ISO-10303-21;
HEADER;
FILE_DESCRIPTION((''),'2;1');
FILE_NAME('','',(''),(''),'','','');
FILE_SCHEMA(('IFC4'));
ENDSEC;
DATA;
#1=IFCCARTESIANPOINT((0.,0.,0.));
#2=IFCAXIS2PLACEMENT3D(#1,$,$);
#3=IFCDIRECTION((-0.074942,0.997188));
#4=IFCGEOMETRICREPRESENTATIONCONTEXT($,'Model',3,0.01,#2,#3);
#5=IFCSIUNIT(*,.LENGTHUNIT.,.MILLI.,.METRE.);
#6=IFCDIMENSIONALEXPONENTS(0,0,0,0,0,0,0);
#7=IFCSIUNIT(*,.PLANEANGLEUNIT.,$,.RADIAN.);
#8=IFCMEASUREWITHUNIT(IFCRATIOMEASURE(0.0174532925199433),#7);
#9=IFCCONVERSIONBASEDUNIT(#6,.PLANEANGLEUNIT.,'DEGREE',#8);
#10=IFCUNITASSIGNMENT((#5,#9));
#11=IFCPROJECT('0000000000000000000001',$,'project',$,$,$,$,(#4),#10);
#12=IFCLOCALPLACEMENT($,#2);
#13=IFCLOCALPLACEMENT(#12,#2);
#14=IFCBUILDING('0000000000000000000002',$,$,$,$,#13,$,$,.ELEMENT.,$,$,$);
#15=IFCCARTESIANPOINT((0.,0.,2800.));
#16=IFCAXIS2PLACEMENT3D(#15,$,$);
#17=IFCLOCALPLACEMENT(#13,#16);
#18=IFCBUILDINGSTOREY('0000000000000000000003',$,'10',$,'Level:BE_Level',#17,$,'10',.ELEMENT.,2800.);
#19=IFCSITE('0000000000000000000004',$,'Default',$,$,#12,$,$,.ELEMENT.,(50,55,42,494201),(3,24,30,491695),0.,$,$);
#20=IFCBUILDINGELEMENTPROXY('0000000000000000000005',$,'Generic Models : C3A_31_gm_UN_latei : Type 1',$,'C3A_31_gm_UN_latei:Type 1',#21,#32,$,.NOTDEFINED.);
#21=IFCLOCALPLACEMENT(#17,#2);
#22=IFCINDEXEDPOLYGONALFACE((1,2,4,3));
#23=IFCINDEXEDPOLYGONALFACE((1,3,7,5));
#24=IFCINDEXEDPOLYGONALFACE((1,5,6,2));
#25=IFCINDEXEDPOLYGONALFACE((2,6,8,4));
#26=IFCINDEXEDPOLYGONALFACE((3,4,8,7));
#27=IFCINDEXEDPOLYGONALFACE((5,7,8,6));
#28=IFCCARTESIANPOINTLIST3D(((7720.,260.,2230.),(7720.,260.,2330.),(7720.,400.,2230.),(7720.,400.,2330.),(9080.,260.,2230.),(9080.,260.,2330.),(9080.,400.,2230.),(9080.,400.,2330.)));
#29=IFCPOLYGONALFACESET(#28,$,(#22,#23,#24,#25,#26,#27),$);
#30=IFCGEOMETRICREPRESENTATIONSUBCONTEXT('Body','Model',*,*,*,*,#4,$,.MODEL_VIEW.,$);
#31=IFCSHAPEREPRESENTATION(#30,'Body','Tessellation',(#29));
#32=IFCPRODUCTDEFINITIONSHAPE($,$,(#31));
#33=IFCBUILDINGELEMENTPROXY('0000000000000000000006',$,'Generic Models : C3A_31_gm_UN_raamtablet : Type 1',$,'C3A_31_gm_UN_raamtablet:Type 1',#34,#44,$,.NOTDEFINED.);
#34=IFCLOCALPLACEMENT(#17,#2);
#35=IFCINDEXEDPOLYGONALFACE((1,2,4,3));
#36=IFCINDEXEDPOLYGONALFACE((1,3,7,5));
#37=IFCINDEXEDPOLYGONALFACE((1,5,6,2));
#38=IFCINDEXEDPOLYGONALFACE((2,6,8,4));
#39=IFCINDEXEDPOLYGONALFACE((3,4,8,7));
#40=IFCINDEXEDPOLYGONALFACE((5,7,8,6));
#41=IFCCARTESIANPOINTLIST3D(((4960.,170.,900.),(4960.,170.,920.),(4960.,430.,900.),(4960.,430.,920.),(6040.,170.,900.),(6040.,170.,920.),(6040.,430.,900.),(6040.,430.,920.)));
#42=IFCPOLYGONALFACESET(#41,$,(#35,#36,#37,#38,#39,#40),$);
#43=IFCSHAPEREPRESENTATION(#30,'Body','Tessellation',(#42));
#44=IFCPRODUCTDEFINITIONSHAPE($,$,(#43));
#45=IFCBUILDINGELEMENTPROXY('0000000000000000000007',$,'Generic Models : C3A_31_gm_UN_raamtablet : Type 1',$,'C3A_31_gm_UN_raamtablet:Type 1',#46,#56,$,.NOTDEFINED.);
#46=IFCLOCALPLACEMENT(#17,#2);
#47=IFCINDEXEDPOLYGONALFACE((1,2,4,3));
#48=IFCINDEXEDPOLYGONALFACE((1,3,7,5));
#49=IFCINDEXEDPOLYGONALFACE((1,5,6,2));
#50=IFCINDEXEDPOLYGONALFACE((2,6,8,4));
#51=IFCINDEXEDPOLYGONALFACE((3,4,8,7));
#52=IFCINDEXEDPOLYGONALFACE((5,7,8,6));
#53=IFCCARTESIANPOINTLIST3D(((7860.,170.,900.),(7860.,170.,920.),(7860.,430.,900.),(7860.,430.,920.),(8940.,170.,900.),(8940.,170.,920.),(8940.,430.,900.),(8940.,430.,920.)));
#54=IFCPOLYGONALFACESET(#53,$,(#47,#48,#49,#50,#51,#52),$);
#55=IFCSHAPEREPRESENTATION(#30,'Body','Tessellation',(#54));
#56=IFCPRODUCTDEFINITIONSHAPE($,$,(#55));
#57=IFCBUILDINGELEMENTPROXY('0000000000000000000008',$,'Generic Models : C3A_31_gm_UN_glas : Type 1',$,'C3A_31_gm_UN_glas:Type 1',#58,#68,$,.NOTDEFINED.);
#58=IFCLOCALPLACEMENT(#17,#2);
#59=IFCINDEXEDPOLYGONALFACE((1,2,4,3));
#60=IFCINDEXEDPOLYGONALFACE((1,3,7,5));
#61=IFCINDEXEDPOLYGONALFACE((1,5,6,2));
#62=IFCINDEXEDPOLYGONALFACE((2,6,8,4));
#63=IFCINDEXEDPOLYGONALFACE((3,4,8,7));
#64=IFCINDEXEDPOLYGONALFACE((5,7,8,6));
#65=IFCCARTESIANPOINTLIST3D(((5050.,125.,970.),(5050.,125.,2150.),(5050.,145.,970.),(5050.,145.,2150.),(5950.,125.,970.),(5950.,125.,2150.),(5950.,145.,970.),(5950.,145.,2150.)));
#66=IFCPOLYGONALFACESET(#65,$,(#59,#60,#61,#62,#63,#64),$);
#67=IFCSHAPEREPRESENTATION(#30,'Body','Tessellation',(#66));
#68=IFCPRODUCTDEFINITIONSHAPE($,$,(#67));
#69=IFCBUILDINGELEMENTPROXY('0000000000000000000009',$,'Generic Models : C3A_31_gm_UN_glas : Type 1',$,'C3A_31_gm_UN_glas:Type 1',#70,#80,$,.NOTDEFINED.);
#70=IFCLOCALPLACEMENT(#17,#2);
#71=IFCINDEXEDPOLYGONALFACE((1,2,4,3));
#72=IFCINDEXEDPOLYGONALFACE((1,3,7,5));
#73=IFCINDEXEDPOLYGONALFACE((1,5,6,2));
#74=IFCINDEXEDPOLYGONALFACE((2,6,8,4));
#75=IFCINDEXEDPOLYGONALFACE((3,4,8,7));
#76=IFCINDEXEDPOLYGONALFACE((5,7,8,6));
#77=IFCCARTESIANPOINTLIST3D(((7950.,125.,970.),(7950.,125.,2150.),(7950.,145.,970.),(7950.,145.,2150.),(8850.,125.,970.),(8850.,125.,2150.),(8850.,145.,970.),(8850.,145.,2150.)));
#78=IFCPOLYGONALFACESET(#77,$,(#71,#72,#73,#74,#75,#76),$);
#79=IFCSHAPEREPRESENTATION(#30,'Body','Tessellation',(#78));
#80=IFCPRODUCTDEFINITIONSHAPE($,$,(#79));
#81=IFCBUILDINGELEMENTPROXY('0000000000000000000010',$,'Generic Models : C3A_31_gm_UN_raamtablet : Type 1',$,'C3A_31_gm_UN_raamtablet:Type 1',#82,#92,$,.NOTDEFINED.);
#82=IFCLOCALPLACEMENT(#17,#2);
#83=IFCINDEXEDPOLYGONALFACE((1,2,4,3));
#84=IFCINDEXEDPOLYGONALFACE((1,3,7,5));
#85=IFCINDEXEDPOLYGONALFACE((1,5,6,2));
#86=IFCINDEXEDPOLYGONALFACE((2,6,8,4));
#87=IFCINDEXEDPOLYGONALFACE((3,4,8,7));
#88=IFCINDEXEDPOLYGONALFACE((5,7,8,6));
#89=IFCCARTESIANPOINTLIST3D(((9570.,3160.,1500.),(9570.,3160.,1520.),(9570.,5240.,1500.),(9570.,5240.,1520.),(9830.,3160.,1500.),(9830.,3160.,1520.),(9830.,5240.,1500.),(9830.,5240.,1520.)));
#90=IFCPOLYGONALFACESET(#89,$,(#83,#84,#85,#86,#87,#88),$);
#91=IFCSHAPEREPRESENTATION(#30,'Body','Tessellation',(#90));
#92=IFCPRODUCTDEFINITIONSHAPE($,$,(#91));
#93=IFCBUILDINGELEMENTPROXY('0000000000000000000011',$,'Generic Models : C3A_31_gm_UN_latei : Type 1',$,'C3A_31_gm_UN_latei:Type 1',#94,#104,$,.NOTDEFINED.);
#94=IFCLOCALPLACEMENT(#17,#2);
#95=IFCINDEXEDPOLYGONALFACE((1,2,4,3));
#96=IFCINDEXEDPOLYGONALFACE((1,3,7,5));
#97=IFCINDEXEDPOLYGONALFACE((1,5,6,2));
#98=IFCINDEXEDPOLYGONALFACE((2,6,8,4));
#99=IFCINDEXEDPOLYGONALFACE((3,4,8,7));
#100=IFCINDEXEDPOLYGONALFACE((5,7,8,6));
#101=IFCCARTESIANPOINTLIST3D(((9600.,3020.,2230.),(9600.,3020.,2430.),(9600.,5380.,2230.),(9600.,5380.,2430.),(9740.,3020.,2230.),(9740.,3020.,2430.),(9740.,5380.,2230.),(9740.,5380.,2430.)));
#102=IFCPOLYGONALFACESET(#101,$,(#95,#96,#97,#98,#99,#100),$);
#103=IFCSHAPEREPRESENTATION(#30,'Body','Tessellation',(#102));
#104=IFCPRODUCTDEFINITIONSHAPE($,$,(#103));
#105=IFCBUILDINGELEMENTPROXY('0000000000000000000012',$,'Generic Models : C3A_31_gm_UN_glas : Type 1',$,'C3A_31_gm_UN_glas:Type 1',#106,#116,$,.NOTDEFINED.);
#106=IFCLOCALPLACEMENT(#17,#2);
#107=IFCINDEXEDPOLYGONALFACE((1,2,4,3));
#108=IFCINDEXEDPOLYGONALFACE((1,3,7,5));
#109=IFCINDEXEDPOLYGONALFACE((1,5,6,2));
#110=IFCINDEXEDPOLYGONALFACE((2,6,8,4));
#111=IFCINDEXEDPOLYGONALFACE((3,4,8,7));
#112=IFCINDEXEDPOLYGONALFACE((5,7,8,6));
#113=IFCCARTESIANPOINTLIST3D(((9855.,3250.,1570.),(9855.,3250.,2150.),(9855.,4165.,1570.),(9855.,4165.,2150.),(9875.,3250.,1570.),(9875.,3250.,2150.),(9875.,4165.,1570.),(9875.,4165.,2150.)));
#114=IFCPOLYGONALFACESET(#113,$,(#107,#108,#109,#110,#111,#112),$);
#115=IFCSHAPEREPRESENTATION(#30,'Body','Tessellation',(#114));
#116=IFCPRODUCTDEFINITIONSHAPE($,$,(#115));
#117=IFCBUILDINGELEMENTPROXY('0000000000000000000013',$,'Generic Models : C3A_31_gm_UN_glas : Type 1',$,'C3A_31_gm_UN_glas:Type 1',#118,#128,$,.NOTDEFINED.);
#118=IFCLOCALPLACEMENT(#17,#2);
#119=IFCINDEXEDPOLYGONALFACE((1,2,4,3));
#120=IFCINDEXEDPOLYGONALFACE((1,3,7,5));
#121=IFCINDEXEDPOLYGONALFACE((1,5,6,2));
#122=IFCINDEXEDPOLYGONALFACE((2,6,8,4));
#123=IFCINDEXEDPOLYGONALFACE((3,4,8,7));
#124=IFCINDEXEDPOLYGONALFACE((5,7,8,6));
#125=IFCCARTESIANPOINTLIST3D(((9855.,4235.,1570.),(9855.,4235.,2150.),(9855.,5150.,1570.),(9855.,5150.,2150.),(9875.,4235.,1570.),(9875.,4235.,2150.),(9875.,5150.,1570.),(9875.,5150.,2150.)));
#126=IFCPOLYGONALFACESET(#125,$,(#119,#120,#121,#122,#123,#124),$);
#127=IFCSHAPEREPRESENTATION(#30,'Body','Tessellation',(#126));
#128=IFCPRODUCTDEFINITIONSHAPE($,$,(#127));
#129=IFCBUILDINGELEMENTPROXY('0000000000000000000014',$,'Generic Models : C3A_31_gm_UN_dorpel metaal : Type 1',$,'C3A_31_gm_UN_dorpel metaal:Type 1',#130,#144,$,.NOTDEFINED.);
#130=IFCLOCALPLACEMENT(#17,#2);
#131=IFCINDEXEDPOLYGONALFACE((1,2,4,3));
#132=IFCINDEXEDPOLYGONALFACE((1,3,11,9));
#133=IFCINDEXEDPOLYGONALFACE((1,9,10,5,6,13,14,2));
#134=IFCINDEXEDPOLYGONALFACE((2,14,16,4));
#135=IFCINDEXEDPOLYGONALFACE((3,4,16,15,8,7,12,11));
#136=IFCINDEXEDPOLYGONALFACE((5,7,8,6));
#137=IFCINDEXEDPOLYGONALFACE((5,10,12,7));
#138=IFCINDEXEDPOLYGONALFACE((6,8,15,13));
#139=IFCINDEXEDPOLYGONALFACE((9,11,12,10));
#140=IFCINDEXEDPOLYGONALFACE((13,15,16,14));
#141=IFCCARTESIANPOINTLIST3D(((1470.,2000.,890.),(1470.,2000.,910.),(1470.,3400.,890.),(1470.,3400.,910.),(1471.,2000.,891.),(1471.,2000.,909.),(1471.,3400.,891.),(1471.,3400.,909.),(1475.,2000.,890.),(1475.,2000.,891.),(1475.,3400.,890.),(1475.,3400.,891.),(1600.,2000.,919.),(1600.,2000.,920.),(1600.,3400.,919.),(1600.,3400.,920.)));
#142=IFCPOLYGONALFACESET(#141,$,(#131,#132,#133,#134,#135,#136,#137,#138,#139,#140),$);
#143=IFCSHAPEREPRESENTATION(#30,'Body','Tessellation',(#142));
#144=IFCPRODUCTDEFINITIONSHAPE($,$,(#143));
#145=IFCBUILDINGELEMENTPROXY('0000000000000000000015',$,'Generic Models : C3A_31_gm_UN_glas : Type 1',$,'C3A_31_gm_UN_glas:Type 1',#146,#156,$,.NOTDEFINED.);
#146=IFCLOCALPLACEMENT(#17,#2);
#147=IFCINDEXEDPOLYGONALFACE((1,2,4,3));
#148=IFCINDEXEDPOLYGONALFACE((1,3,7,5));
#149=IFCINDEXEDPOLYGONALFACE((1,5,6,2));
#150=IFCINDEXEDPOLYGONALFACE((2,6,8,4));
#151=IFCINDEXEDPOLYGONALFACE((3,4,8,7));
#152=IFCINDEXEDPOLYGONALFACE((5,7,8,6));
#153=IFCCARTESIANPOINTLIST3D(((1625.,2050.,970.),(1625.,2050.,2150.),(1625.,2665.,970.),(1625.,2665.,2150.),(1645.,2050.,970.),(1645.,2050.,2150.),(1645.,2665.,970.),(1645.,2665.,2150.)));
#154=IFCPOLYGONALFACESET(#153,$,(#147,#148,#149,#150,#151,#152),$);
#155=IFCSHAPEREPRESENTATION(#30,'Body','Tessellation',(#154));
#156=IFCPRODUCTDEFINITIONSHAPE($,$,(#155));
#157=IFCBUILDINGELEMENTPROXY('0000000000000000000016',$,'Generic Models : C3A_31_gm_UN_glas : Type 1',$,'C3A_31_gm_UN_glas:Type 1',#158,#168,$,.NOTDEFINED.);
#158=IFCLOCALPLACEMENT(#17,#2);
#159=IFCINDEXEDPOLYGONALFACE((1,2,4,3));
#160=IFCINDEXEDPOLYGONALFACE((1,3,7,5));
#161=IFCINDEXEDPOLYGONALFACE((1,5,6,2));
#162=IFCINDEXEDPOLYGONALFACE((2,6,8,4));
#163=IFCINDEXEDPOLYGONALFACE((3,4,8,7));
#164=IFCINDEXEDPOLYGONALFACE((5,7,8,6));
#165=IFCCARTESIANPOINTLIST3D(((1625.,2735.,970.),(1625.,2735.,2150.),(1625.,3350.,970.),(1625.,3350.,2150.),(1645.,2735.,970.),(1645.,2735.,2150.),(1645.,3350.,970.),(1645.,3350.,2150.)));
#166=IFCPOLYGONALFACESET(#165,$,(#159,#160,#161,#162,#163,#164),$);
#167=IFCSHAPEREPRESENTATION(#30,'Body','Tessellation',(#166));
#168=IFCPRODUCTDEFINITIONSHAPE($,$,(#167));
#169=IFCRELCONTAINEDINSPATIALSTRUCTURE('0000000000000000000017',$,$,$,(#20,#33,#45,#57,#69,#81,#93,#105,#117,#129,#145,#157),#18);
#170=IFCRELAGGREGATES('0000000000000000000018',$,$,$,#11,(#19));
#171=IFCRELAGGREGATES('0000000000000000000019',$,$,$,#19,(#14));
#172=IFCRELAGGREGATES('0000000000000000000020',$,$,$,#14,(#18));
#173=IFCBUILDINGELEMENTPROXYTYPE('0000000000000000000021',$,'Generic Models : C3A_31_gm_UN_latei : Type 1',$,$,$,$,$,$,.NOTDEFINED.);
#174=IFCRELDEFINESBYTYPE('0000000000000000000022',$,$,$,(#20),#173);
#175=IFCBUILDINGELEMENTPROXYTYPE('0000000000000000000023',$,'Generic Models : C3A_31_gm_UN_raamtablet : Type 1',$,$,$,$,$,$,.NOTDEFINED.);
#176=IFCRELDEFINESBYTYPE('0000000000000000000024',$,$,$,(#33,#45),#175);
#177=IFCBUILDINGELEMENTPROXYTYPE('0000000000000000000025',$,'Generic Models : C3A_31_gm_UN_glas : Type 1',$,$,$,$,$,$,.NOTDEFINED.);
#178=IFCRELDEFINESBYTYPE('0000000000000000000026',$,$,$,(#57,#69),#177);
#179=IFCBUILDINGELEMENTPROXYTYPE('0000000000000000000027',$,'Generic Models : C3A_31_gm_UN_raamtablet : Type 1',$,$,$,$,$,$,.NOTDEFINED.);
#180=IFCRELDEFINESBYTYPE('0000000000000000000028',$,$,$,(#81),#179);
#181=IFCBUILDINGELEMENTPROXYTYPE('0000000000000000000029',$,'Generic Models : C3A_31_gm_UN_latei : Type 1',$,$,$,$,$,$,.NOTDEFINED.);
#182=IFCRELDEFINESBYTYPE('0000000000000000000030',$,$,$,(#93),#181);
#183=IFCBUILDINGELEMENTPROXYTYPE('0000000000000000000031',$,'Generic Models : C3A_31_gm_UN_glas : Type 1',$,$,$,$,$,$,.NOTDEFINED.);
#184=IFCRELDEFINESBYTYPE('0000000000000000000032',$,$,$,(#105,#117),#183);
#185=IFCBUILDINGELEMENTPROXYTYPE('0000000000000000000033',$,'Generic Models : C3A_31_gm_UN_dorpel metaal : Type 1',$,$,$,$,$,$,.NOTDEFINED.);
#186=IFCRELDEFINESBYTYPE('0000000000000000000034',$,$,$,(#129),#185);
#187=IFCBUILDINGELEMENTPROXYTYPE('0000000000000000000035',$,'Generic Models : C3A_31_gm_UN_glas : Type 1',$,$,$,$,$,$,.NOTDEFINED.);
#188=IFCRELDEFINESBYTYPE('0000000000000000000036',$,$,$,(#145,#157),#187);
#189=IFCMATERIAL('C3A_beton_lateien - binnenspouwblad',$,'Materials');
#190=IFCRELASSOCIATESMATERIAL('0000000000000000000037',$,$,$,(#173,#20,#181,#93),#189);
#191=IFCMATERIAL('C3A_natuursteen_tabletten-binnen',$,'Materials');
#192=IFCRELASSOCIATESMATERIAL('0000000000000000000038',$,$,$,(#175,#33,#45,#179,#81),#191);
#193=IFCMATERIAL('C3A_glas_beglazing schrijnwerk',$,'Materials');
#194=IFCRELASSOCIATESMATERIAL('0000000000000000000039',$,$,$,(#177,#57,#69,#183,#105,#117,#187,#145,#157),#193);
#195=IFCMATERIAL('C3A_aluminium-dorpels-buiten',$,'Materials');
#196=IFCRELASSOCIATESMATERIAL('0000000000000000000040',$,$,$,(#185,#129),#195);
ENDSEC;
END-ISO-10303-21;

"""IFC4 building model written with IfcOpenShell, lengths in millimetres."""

from ifc_helpers import new_model, entity, si_unit, converted_unit, direction, frame, frame_2d, origin, origin_2d_with_axis, place, context, subcontext, project, spatial, polyline, rectangle, outline, extrude, source, transform, mapped, material, type_object, type_shapes, element, save


model = new_model("IFC4")

# Units and contexts
model_context = context("Model", 3, precision=0.01, world=origin(), true_north=direction((-0.074942, 0.997188)))
body_context = subcontext(model_context, "Body", "Model", "MODEL_VIEW")
ifc_project = project(units=[si_unit("LENGTHUNIT", "METRE", prefix="MILLI"), converted_unit("PLANEANGLEUNIT", "DEGREE", entity("IfcRatioMeasure", 0.0174532925199433), si_unit("PLANEANGLEUNIT", "RADIAN"), dimensions=[0, 0, 0, 0, 0, 0, 0])], contexts=[model_context])

# Site, building, storey
site_placement = place(None, origin())
site = spatial("IfcSite", under=ifc_project, at=site_placement, Name="Default", CompositionType="ELEMENT", RefLatitude=(50, 55, 42, 494201), RefLongitude=(3, 24, 30, 491695), RefElevation=0.0)
building_placement = place(site_placement, origin())
building = spatial("IfcBuilding", under=site, at=building_placement, CompositionType="ELEMENT")
storey_placement = place(building_placement, frame((0.0, 0.0, 2800.0)))
storey = spatial("IfcBuildingStorey", under=building, at=storey_placement, Name="10", ObjectType="Level:BE_Level", LongName="10", CompositionType="ELEMENT", Elevation=2800.0)

# Building element proxies
ifc_material_1 = material(Name="C3A_natuursteen_tabletten-binnen", Category="Materials")
ifc_material_2 = material(Name="C3A_beton_lateien - binnenspouwblad", Category="Materials")
building_element_proxy_type_1 = type_object("IfcBuildingElementProxyType", Name="Generic Models : C3A_31_gm_UN_latei : Type 1", PredefinedType="NOTDEFINED", material=ifc_material_2)
shared_shape_1 = source(origin(), body_context, "Body", "SweptSolid", [
    extrude(rectangle(XDim=1360.0, YDim=140.0, at=origin_2d_with_axis()), frame((0.0, 70.0, 0.0), z_axis=(0.0, 0.0, 1.0), x_axis=(-1.0, 0.0, 0.0)), (0.0, 0.0, 1.0), 100.0),
])
type_shapes(building_element_proxy_type_1, [shared_shape_1])
for number, where, z_axis, x_axis, name in (
    (1, (8400.0, 400.0, 2230.0), (0.0, 0.0, 1.0), (-1.0, 0.0, 0.0), "Generic Models : C3A_31_gm_UN_latei : Type 1"),
):
    element("IfcBuildingElementProxy", number, at=place(storey_placement, frame(where, z_axis=z_axis, x_axis=x_axis)), inside=storey, type_object=building_element_proxy_type_1, material=ifc_material_2, Name=name, ObjectType="C3A_31_gm_UN_latei:Type 1", PredefinedType="NOTDEFINED", context=body_context, shape_type="MappedRepresentation", body=[
        mapped(shared_shape_1, transform((0.0, 0.0, 0.0), scale=1.0)),
    ])
building_element_proxy_type_2 = type_object("IfcBuildingElementProxyType", Name="Generic Models : C3A_31_gm_UN_raamtablet : Type 1", PredefinedType="NOTDEFINED", material=ifc_material_1)
shared_shape_2 = source(origin(), body_context, "Body", "SweptSolid", [
    extrude(rectangle(XDim=1080.0, YDim=260.0, at=origin_2d_with_axis()), frame((0.0, 130.0, 0.0), z_axis=(0.0, 0.0, 1.0), x_axis=(-1.0, 0.0, 0.0)), (0.0, 0.0, 1.0), 20.0),
])
type_shapes(building_element_proxy_type_2, [shared_shape_2])
for number, where, z_axis, x_axis, name in (
    (2, (5500.0, 430.0, 900.0), (0.0, 0.0, 1.0), (-1.0, 0.0, 0.0), "Generic Models : C3A_31_gm_UN_raamtablet : Type 1"),
    (3, (8400.0, 430.0, 900.0), (0.0, 0.0, 1.0), (-1.0, 0.0, 0.0), "Generic Models : C3A_31_gm_UN_raamtablet : Type 1"),
):
    element("IfcBuildingElementProxy", number, at=place(storey_placement, frame(where, z_axis=z_axis, x_axis=x_axis)), inside=storey, type_object=building_element_proxy_type_2, material=ifc_material_1, Name=name, ObjectType="C3A_31_gm_UN_raamtablet:Type 1", PredefinedType="NOTDEFINED", context=body_context, shape_type="MappedRepresentation", body=[
        mapped(shared_shape_2, transform((0.0, 0.0, 0.0), scale=1.0)),
    ])
ifc_material_3 = material(Name="C3A_glas_beglazing schrijnwerk", Category="Materials")
building_element_proxy_type_3 = type_object("IfcBuildingElementProxyType", Name="Generic Models : C3A_31_gm_UN_glas : Type 1", PredefinedType="NOTDEFINED", material=ifc_material_3)
shared_shape_3 = source(origin(), body_context, "Body", "SweptSolid", [
    extrude(rectangle(XDim=900.0, YDim=20.0, at=origin_2d_with_axis()), frame((450.0, 10.0, 0.0), z_axis=(0.0, 0.0, 1.0), x_axis=(-1.0, 0.0, 0.0)), (0.0, 0.0, 1.0), 1180.0),
])
type_shapes(building_element_proxy_type_3, [shared_shape_3])
for number, where, z_axis, x_axis, name in (
    (4, (5950.0, 145.0, 970.0), (0.0, 0.0, 1.0), (-1.0, 0.0, 0.0), "Generic Models : C3A_31_gm_UN_glas : Type 1"),
    (5, (8850.0, 145.0, 970.0), (0.0, 0.0, 1.0), (-1.0, 0.0, 0.0), "Generic Models : C3A_31_gm_UN_glas : Type 1"),
):
    element("IfcBuildingElementProxy", number, at=place(storey_placement, frame(where, z_axis=z_axis, x_axis=x_axis)), inside=storey, type_object=building_element_proxy_type_3, material=ifc_material_3, Name=name, ObjectType="C3A_31_gm_UN_glas:Type 1", PredefinedType="NOTDEFINED", context=body_context, shape_type="MappedRepresentation", body=[
        mapped(shared_shape_3, transform((0.0, 0.0, 0.0), scale=1.0)),
    ])
ifc_material_4 = material(Name="C3A_aluminium-dorpels-buiten", Category="Materials")
building_element_proxy_type_4 = type_object("IfcBuildingElementProxyType", Name="Generic Models : C3A_31_gm_UN_raamtablet : Type 1", PredefinedType="NOTDEFINED", material=ifc_material_1)
shared_shape_4 = source(origin(), body_context, "Body", "SweptSolid", [
    extrude(rectangle(XDim=260.0, YDim=2080.0, at=origin_2d_with_axis()), frame((0.0, -130.0, 0.0), z_axis=(0.0, 0.0, 1.0), x_axis=(0.0, 1.0, 0.0)), (0.0, 0.0, 1.0), 20.0),
])
type_shapes(building_element_proxy_type_4, [shared_shape_4])
proxy_1_placement = place(storey_placement, frame((9570.0, 4200.0, 1500.0), z_axis=(0.0, 0.0, 1.0), x_axis=(0.0, 1.0, 0.0)))
element("IfcBuildingElementProxy", 6, at=proxy_1_placement, inside=storey, type_object=building_element_proxy_type_4, material=ifc_material_1, Name="Generic Models : C3A_31_gm_UN_raamtablet : Type 1", ObjectType="C3A_31_gm_UN_raamtablet:Type 1", PredefinedType="NOTDEFINED", context=body_context, shape_type="MappedRepresentation", body=[
    mapped(shared_shape_4, transform((0.0, 0.0, 0.0), scale=1.0)),
])
building_element_proxy_type_5 = type_object("IfcBuildingElementProxyType", Name="Generic Models : C3A_31_gm_UN_latei : Type 1", PredefinedType="NOTDEFINED", material=ifc_material_2)
shared_shape_5 = source(origin(), body_context, "Body", "SweptSolid", [
    extrude(rectangle(XDim=140.0, YDim=2360.0, at=frame_2d((0.0, 0.0), x_axis=(1.0, 0.0))), frame((0.0, -70.0, 0.0), z_axis=(0.0, 0.0, 1.0), x_axis=(0.0, 1.0, 0.0)), (0.0, 0.0, 1.0), 200.0),
])
type_shapes(building_element_proxy_type_5, [shared_shape_5])
proxy_2_placement = place(storey_placement, frame((9600.0, 4200.0, 2230.0), z_axis=(0.0, 0.0, 1.0), x_axis=(0.0, 1.0, 0.0)))
element("IfcBuildingElementProxy", 7, at=proxy_2_placement, inside=storey, type_object=building_element_proxy_type_5, material=ifc_material_2, Name="Generic Models : C3A_31_gm_UN_latei : Type 1", ObjectType="C3A_31_gm_UN_latei:Type 1", PredefinedType="NOTDEFINED", context=body_context, shape_type="MappedRepresentation", body=[
    mapped(shared_shape_5, transform((0.0, 0.0, 0.0), scale=1.0)),
])
building_element_proxy_type_6 = type_object("IfcBuildingElementProxyType", Name="Generic Models : C3A_31_gm_UN_glas : Type 1", PredefinedType="NOTDEFINED", material=ifc_material_3)
shared_shape_6 = source(origin(), body_context, "Body", "SweptSolid", [
    extrude(rectangle(XDim=20.0, YDim=915.0, at=origin_2d_with_axis()), frame((457.5, 10.0, 0.0), z_axis=(0.0, 0.0, 1.0), x_axis=(0.0, 1.0, 0.0)), (0.0, 0.0, 1.0), 580.0),
])
type_shapes(building_element_proxy_type_6, [shared_shape_6])
for number, where, z_axis, x_axis, name in (
    (8, (9875.0, 3250.0, 1570.0), (0.0, 0.0, 1.0), (0.0, 1.0, 0.0), "Generic Models : C3A_31_gm_UN_glas : Type 1"),
    (9, (9875.0, 4235.0, 1570.0), (0.0, 0.0, 1.0), (0.0, 1.0, 0.0), "Generic Models : C3A_31_gm_UN_glas : Type 1"),
):
    element("IfcBuildingElementProxy", number, at=place(storey_placement, frame(where, z_axis=z_axis, x_axis=x_axis)), inside=storey, type_object=building_element_proxy_type_6, material=ifc_material_3, Name=name, ObjectType="C3A_31_gm_UN_glas:Type 1", PredefinedType="NOTDEFINED", context=body_context, shape_type="MappedRepresentation", body=[
        mapped(shared_shape_6, transform((0.0, 0.0, 0.0), scale=1.0)),
    ])
building_element_proxy_type_7 = type_object("IfcBuildingElementProxyType", Name="Generic Models : C3A_31_gm_UN_dorpel metaal : Type 1", PredefinedType="NOTDEFINED", material=ifc_material_4)
shared_shape_7 = source(origin(), body_context, "Body", "SweptSolid", [
    extrude(outline(polyline([(-33.3, -10.1), (97.1, -10.1), (97.0, -9.1), (-32.4, -9.1), (-33.8, 8.9), (-29.8, 9.2), (-29.9, 10.2), (-34.9, 9.9), (-33.3, -10.1)])), frame((-700.0, 96.0, 2.5), z_axis=(1.0, 0.0, 0.0), x_axis=(0.0, -0.997054, 0.076696)), (0.0, 0.0, 1.0), 1400.0),
])
type_shapes(building_element_proxy_type_7, [shared_shape_7])
proxy_3_placement = place(storey_placement, frame((1600.0, 2700.0, 900.0), z_axis=(0.0, 0.0, 1.0), x_axis=(0.0, 1.0, 0.0)))
element("IfcBuildingElementProxy", 10, at=proxy_3_placement, inside=storey, type_object=building_element_proxy_type_7, material=ifc_material_4, Name="Generic Models : C3A_31_gm_UN_dorpel metaal : Type 1", ObjectType="C3A_31_gm_UN_dorpel metaal:Type 1", PredefinedType="NOTDEFINED", context=body_context, shape_type="MappedRepresentation", body=[
    mapped(shared_shape_7, transform((0.0, 0.0, 0.0), scale=1.0)),
])
building_element_proxy_type_8 = type_object("IfcBuildingElementProxyType", Name="Generic Models : C3A_31_gm_UN_glas : Type 1", PredefinedType="NOTDEFINED", material=ifc_material_3)
shared_shape_8 = source(origin(), body_context, "Body", "SweptSolid", [
    extrude(rectangle(XDim=615.0, YDim=20.0, at=origin_2d_with_axis()), frame((307.5, 10.0, 0.0), z_axis=(0.0, 0.0, 1.0), x_axis=(-1.0, 0.0, 0.0)), (0.0, 0.0, 1.0), 1180.0),
])
type_shapes(building_element_proxy_type_8, [shared_shape_8])
for number, where, z_axis, x_axis, name in (
    (11, (1645.0, 2050.0, 970.0), (0.0, 0.0, 1.0), (0.0, 1.0, 0.0), "Generic Models : C3A_31_gm_UN_glas : Type 1"),
    (12, (1645.0, 2735.0, 970.0), (0.0, 0.0, 1.0), (0.0, 1.0, 0.0), "Generic Models : C3A_31_gm_UN_glas : Type 1"),
):
    element("IfcBuildingElementProxy", number, at=place(storey_placement, frame(where, z_axis=z_axis, x_axis=x_axis)), inside=storey, type_object=building_element_proxy_type_8, material=ifc_material_3, Name=name, ObjectType="C3A_31_gm_UN_glas:Type 1", PredefinedType="NOTDEFINED", context=body_context, shape_type="MappedRepresentation", body=[
        mapped(shared_shape_8, transform((0.0, 0.0, 0.0), scale=1.0)),
    ])

save(model, "model.ifc")
